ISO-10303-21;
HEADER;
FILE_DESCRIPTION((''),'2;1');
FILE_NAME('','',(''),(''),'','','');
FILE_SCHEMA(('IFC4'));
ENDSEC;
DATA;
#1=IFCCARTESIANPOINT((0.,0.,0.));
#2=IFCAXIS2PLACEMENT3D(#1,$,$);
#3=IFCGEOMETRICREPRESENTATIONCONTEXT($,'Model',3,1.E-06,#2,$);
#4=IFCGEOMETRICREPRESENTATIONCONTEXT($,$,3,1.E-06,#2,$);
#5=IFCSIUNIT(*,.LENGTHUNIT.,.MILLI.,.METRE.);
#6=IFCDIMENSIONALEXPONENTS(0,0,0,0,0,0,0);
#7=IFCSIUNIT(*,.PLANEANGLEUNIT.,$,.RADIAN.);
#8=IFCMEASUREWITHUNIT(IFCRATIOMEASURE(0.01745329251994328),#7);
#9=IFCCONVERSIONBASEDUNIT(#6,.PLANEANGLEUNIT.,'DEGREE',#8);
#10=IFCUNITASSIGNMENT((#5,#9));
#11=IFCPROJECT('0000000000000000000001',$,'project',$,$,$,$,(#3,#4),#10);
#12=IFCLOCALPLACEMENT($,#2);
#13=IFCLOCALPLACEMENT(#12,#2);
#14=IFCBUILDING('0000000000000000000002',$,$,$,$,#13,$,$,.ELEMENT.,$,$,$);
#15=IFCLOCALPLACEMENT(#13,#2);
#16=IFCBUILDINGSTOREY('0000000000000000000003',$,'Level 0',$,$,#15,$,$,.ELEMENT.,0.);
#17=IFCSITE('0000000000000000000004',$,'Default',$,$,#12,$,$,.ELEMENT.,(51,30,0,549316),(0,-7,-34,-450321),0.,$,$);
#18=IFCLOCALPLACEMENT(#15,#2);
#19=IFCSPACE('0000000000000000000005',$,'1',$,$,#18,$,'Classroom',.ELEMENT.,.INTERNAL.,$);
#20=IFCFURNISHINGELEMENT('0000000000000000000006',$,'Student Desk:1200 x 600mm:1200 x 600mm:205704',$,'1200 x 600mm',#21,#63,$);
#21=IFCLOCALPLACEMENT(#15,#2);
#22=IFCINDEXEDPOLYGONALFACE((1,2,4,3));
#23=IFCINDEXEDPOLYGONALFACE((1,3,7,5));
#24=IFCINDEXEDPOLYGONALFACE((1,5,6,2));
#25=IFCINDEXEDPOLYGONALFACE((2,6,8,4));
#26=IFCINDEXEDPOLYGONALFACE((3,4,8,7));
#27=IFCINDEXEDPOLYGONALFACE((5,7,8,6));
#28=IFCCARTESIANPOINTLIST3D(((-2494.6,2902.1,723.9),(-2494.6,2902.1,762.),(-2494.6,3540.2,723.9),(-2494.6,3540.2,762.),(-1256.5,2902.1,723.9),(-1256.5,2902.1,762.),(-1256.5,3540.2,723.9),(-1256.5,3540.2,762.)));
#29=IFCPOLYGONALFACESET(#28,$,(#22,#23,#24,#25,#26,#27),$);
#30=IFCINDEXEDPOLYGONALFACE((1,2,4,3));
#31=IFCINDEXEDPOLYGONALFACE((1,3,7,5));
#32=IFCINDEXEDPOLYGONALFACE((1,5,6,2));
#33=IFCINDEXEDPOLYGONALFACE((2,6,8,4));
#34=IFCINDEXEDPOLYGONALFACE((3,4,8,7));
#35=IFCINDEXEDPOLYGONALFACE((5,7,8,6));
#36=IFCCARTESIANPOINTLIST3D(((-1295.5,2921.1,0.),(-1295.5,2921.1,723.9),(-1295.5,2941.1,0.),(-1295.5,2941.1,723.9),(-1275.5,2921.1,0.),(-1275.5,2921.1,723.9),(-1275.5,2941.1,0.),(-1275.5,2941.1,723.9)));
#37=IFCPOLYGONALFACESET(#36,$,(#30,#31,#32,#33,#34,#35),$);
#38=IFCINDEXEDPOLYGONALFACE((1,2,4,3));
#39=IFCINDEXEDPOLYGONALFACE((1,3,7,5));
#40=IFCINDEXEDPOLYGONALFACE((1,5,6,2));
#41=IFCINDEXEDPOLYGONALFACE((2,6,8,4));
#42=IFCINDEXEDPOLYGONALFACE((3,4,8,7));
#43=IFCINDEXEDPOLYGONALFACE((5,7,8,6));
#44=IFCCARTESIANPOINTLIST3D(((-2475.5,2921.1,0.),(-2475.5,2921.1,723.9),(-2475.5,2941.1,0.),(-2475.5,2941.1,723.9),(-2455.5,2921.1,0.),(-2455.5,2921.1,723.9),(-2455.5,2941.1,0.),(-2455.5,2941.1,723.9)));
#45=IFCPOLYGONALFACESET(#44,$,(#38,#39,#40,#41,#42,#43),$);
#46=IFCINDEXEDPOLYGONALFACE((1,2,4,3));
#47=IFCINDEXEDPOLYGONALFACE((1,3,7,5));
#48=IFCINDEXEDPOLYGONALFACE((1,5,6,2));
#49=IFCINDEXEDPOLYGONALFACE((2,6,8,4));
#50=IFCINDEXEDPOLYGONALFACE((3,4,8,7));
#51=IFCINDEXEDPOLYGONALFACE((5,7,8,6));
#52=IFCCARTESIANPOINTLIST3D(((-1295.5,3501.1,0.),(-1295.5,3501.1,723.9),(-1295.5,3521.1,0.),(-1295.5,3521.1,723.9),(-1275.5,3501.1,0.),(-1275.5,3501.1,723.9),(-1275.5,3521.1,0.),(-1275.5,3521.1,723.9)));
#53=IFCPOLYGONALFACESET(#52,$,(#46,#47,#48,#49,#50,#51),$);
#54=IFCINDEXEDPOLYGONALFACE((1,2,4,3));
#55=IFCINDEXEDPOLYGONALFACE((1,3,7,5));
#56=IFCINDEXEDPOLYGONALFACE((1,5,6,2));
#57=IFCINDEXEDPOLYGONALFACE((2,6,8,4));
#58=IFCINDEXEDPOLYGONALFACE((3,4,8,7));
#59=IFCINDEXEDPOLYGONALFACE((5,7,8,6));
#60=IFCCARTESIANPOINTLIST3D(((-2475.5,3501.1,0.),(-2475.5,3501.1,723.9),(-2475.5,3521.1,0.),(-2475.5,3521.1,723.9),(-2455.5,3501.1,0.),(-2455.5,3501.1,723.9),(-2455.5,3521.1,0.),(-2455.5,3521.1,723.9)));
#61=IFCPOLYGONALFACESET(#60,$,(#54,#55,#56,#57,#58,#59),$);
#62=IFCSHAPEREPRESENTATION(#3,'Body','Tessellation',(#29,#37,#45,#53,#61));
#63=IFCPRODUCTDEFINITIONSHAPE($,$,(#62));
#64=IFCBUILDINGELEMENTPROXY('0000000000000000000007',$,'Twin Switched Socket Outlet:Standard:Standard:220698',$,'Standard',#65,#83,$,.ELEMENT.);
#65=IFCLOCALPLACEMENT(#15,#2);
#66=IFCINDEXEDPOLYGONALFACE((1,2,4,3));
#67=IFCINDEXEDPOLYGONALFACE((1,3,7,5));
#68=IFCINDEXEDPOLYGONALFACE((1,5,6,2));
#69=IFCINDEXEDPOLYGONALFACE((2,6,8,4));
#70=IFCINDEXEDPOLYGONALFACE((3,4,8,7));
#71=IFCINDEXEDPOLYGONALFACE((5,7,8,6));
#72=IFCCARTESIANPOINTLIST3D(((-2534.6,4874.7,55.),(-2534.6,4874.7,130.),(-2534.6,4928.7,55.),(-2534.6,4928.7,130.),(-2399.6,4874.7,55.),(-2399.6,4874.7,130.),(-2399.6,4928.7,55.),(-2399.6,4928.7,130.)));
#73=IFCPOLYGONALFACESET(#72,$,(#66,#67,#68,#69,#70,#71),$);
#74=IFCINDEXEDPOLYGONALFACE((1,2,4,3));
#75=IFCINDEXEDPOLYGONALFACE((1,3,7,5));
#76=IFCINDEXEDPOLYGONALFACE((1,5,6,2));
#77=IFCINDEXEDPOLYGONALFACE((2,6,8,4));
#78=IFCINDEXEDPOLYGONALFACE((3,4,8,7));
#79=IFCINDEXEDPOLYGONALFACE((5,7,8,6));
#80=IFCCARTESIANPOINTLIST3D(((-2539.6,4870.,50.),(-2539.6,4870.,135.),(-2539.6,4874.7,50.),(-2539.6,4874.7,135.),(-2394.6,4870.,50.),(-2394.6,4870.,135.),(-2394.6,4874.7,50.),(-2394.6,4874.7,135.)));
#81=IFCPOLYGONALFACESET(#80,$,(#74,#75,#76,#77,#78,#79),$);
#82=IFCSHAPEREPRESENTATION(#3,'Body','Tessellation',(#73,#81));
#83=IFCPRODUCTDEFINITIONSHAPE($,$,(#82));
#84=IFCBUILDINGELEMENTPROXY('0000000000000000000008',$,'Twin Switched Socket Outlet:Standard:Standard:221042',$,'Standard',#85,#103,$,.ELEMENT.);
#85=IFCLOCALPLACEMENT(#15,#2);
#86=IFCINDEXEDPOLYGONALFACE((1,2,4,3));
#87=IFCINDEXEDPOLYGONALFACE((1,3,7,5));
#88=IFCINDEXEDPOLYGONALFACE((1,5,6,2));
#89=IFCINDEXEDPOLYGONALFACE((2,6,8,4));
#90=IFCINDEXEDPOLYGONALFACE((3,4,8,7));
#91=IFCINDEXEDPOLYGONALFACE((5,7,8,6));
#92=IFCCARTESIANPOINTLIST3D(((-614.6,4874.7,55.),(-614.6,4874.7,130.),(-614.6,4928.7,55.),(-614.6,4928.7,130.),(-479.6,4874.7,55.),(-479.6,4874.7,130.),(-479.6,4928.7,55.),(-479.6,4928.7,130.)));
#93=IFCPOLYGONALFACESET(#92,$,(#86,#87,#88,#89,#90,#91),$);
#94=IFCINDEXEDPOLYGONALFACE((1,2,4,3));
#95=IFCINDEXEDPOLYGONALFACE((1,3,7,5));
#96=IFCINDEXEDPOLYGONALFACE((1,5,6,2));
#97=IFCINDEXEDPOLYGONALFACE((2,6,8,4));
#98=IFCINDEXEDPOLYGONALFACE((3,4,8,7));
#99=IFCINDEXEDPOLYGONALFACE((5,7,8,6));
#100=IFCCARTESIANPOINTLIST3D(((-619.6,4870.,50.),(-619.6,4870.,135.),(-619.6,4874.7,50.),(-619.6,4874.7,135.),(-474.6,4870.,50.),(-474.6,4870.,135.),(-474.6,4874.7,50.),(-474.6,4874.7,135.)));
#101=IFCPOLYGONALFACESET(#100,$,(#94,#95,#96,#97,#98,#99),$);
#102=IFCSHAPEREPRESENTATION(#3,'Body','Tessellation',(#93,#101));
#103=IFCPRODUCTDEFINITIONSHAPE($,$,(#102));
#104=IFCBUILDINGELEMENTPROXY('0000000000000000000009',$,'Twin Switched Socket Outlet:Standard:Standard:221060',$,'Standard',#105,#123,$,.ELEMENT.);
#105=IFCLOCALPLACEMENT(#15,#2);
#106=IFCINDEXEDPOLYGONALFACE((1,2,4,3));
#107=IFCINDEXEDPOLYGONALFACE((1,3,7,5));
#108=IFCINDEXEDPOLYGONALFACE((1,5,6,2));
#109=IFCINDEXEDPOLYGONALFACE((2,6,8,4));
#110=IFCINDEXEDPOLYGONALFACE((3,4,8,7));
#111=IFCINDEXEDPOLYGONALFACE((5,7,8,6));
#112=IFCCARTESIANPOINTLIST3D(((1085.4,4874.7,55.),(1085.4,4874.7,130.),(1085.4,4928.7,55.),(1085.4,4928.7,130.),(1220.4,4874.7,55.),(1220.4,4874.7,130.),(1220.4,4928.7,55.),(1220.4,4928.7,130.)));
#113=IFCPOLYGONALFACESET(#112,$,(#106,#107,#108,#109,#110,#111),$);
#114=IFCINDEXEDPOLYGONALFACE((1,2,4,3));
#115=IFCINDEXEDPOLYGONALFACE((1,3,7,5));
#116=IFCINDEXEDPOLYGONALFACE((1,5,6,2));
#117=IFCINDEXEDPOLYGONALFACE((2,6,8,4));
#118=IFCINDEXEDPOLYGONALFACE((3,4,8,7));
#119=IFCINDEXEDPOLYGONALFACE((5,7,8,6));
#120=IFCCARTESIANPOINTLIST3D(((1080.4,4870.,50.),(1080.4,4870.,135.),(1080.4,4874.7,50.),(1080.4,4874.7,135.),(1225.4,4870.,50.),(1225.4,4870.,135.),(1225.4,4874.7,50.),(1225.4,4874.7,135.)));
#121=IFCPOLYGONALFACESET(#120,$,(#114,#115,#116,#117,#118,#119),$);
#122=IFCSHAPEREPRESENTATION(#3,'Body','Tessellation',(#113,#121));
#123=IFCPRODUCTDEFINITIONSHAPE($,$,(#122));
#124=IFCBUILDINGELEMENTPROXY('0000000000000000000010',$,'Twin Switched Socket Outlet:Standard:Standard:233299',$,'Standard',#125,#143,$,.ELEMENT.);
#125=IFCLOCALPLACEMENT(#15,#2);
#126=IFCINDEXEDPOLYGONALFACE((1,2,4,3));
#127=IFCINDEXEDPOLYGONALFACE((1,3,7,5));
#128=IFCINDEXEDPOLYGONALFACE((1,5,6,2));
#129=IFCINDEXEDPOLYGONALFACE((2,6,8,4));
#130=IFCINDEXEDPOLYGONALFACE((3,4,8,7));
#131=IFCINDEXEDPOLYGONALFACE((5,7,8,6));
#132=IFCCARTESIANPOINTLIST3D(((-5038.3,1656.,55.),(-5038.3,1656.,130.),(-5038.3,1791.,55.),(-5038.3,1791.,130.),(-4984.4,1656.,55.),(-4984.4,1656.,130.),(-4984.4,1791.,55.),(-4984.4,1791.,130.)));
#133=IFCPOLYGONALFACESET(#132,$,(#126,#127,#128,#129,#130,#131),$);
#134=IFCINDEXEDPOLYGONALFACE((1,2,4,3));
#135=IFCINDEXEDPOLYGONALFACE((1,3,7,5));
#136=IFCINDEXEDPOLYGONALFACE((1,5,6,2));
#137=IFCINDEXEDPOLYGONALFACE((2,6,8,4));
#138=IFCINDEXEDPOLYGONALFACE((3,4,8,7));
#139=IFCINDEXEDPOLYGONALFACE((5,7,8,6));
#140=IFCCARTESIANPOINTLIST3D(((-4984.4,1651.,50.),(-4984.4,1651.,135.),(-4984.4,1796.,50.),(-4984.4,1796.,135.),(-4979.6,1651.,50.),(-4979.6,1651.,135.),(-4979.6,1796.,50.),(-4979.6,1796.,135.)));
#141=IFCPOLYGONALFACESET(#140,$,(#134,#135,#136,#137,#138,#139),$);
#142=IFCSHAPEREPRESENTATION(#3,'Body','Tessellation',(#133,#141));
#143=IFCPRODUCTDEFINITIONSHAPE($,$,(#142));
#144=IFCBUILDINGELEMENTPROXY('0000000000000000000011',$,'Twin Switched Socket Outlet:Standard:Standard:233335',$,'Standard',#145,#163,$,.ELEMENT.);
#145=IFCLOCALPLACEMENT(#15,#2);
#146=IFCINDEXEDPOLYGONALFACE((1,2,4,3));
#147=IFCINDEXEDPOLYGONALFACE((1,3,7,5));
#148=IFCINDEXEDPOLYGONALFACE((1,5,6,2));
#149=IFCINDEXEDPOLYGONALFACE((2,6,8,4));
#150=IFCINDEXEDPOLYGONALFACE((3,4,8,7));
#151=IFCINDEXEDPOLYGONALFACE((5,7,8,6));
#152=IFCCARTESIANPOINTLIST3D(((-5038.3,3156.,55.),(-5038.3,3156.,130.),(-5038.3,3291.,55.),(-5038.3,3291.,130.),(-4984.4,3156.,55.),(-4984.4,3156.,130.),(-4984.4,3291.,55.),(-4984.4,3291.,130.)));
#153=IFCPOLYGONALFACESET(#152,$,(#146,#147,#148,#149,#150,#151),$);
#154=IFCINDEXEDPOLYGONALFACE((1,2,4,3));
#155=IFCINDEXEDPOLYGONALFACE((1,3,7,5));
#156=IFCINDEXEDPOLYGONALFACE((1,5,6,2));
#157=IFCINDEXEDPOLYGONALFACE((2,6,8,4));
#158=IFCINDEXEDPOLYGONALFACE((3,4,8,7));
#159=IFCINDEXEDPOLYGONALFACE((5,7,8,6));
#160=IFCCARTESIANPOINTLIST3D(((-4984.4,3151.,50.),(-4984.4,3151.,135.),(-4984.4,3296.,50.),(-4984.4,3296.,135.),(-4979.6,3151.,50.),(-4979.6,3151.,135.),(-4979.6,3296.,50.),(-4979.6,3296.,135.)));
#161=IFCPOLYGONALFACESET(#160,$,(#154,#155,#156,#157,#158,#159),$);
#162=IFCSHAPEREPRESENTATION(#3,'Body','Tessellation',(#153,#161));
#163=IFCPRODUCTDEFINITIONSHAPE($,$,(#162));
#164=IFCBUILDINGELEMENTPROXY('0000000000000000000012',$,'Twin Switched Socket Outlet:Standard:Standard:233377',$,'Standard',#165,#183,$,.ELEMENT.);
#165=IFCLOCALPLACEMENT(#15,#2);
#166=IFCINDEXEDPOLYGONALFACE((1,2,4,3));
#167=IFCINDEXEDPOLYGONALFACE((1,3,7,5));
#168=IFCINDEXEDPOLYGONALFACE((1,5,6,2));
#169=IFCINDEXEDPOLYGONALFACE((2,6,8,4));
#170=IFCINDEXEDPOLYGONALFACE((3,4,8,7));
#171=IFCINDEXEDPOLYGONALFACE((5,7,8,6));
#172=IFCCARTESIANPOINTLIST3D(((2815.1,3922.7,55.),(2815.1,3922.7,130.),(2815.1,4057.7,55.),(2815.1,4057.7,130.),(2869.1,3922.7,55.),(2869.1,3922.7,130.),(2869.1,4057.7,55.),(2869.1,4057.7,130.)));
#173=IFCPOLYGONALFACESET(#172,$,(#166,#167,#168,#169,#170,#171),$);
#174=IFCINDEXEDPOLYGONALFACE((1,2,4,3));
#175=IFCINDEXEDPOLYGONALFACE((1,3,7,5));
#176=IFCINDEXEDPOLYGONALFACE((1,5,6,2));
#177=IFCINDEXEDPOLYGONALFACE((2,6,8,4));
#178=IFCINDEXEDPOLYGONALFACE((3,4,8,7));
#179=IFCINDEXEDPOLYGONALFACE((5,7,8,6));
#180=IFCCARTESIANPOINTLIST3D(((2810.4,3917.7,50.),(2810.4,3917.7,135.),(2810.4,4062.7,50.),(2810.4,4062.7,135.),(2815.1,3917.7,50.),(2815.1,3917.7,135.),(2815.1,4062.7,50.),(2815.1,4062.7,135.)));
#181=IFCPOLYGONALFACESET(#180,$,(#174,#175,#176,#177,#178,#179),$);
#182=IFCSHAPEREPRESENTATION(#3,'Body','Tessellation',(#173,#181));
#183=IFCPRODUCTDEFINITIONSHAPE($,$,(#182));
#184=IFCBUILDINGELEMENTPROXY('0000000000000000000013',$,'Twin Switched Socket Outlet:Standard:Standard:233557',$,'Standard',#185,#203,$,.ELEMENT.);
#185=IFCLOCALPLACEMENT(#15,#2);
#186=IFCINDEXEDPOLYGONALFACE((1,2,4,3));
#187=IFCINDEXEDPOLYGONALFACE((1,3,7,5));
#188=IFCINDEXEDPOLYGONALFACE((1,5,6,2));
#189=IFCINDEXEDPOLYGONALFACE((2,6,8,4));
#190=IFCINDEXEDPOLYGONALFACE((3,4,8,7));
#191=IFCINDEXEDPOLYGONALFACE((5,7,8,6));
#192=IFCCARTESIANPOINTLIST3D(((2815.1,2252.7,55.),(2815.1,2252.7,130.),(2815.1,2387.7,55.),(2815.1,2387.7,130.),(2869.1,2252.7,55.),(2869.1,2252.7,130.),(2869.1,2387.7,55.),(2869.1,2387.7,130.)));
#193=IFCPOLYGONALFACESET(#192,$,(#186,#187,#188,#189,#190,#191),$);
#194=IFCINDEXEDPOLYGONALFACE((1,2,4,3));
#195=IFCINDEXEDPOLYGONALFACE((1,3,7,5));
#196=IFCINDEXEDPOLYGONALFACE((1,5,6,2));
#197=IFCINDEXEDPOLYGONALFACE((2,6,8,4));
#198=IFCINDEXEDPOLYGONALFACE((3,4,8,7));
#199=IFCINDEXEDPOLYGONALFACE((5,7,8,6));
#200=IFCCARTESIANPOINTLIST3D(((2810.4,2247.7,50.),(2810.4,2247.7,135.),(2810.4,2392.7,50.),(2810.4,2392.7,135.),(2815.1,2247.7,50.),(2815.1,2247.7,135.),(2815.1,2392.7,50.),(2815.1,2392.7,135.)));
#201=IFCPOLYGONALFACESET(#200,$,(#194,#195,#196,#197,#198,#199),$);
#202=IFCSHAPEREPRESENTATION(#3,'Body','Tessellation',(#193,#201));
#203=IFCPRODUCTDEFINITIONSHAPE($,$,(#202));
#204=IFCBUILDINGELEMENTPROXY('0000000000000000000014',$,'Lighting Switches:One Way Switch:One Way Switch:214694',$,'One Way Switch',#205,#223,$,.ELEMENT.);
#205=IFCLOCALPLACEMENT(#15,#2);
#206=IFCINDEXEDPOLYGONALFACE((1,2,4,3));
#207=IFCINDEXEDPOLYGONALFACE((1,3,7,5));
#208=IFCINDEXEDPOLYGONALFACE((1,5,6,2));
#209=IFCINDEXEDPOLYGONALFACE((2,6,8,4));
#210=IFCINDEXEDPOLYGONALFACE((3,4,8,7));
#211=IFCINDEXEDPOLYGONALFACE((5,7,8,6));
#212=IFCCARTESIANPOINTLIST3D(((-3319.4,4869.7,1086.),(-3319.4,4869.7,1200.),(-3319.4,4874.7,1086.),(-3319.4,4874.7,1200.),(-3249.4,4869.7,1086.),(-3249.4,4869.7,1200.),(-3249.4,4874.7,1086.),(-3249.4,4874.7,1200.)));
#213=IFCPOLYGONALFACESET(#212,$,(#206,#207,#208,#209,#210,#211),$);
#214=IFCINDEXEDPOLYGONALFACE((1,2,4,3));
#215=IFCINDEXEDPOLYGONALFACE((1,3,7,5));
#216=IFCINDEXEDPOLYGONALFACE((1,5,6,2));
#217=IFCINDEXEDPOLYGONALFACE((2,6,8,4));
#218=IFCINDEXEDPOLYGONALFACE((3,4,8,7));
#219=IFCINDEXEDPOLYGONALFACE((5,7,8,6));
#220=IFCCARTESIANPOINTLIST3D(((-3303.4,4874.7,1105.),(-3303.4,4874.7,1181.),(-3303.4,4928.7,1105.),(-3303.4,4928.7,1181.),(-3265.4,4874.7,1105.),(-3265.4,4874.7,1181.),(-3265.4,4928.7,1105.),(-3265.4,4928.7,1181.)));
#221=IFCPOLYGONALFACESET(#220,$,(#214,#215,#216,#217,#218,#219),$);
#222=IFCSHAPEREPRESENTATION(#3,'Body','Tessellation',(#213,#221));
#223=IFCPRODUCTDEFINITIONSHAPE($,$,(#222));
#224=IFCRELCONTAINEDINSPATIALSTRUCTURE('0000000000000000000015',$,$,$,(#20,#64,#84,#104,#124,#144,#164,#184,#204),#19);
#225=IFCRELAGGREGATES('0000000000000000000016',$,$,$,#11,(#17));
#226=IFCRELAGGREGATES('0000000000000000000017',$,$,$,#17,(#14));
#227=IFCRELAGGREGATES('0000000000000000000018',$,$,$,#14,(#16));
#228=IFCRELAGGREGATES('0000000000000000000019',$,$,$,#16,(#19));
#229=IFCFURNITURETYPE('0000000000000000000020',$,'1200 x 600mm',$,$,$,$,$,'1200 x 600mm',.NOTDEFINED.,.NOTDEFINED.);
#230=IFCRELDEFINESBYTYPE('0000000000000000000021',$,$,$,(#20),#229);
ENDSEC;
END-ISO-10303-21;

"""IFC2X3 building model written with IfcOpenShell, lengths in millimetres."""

from ifc_helpers import new_model, entity, si_unit, converted_unit, frame, origin, origin_2d_with_axis, place, context, project, spatial, rectangle, extrude, source, transform, mapped, type_object, type_shapes, element, save


model = new_model("IFC2X3")

# Units and contexts
model_context = context("Model", 3, precision=1e-06, world=origin())
context_of_model = context(None, 3, precision=1e-06, world=origin())
ifc_project = project(units=[si_unit("LENGTHUNIT", "METRE", prefix="MILLI"), converted_unit("PLANEANGLEUNIT", "DEGREE", entity("IfcRatioMeasure", 0.01745329251994328), si_unit("PLANEANGLEUNIT", "RADIAN"), dimensions=[0, 0, 0, 0, 0, 0, 0])], contexts=[model_context, context_of_model])

# Site, building, storey
site_placement = place(None, origin())
site = spatial("IfcSite", under=ifc_project, at=site_placement, Name="Default", CompositionType="ELEMENT", RefLatitude=(51, 30, 0, 549316), RefLongitude=(0, -7, -34, -450321), RefElevation=0.0)
building_placement = place(site_placement, origin())
building = spatial("IfcBuilding", under=site, at=building_placement, CompositionType="ELEMENT")
storey_placement = place(building_placement, origin())
storey = spatial("IfcBuildingStorey", under=building, at=storey_placement, Name="Level 0", CompositionType="ELEMENT", Elevation=0.0)

# Shared definitions
space_placement = place(storey_placement, origin())
space = spatial("IfcSpace", under=storey, at=space_placement, Name="1", LongName="Classroom", CompositionType="ELEMENT", InteriorOrExteriorSpace="INTERNAL")

# Furnishing element
furniture_type = type_object("IfcFurnitureType", Name="1200 x 600mm", ElementType="1200 x 600mm", AssemblyPlace="NOTDEFINED")
shared_shape_1 = source(origin(), model_context, "Body", "SweptSolid", [
    extrude(rectangle(XDim=1238.1, YDim=638.1, at=origin_2d_with_axis()), frame((600.0, 300.0, 723.9), z_axis=(0.0, 0.0, 1.0), x_axis=(-1.0, 0.0, 0.0)), (0.0, 0.0, 1.0), 38.1),
    extrude(rectangle(XDim=20.0, YDim=20.0, at=origin_2d_with_axis()), frame((1190.0, 10.0, 0.0)), (0.0, 0.0, 1.0), 723.9),
    extrude(rectangle(XDim=20.0, YDim=20.0, at=origin_2d_with_axis()), frame((10.0, 10.0, 0.0), z_axis=(0.0, 0.0, 1.0), x_axis=(0.0, 1.0, 0.0)), (0.0, 0.0, 1.0), 723.9),
    extrude(rectangle(XDim=20.0, YDim=20.0, at=origin_2d_with_axis()), frame((1190.0, 590.0, 0.0), z_axis=(0.0, 0.0, 1.0), x_axis=(0.0, -1.0, 0.0)), (0.0, 0.0, 1.0), 723.9),
    extrude(rectangle(XDim=20.0, YDim=20.0, at=origin_2d_with_axis()), frame((10.0, 590.0, 0.0), z_axis=(0.0, 0.0, 1.0), x_axis=(-1.0, 0.0, 0.0)), (0.0, 0.0, 1.0), 723.9),
])
type_shapes(furniture_type, [shared_shape_1])
for number, where, name in (
    (1, (-2475.5, 2921.1, 0.0), "Student Desk:1200 x 600mm:1200 x 600mm:205704"),
):
    element("IfcFurnishingElement", number, at=place(space_placement, frame(where)), inside=space, type_object=furniture_type, Name=name, ObjectType="1200 x 600mm", context=model_context, shape_type="MappedRepresentation", body=[
        mapped(shared_shape_1, transform((0.0, 0.0, 0.0), scale=1.0)),
    ])

# Building element proxies
shared_shape_2 = source(origin(), model_context, "Body", "SweptSolid", [
    extrude(rectangle(XDim=135.0, YDim=75.0, at=origin_2d_with_axis()), frame((0.0, 0.0, -54.0), z_axis=(0.0, 0.0, 1.0), x_axis=(-1.0, 0.0, 0.0)), (0.0, 0.0, 1.0), 54.0),
    extrude(rectangle(XDim=145.0, YDim=85.0, at=origin_2d_with_axis()), frame((0.0, 0.0, 0.0), z_axis=(0.0, 0.0, 1.0), x_axis=(-1.0, 0.0, 0.0)), (0.0, 0.0, 1.0), 4.8),
])
for number, where, z_axis, x_axis, name in (
    (2, (-2467.1, 4874.7, 92.5), (0.0, -1.0, 0.0), (1.0, 0.0, 0.0), "Twin Switched Socket Outlet:Standard:Standard:220698"),
    (3, (-547.1, 4874.7, 92.5), (0.0, -1.0, 0.0), (1.0, 0.0, 0.0), "Twin Switched Socket Outlet:Standard:Standard:221042"),
    (4, (1152.9, 4874.7, 92.5), (0.0, -1.0, 0.0), (1.0, 0.0, 0.0), "Twin Switched Socket Outlet:Standard:Standard:221060"),
    (5, (-4984.4, 1723.5, 92.5), (1.0, 0.0, 0.0), (0.0, 1.0, 0.0), "Twin Switched Socket Outlet:Standard:Standard:233299"),
    (6, (-4984.4, 3223.5, 92.5), (1.0, 0.0, 0.0), (0.0, 1.0, 0.0), "Twin Switched Socket Outlet:Standard:Standard:233335"),
    (7, (2815.1, 3990.2, 92.5), (-1.0, 0.0, 0.0), (0.0, -1.0, 0.0), "Twin Switched Socket Outlet:Standard:Standard:233377"),
    (8, (2815.1, 2320.2, 92.5), (-1.0, 0.0, 0.0), (0.0, -1.0, 0.0), "Twin Switched Socket Outlet:Standard:Standard:233557"),
):
    element("IfcBuildingElementProxy", number, at=place(space_placement, frame(where, z_axis=z_axis, x_axis=x_axis)), inside=space, Name=name, ObjectType="Standard", CompositionType="ELEMENT", context=model_context, shape_type="MappedRepresentation", body=[
        mapped(shared_shape_2, transform((0.0, 0.0, 0.0), scale=1.0)),
    ])
shared_shape_3 = source(origin(), model_context, "Body", "SweptSolid", [
    extrude(rectangle(XDim=114.0, YDim=70.0, at=origin_2d_with_axis()), frame((0.0, -57.0, 0.0), z_axis=(0.0, 0.0, 1.0), x_axis=(0.0, 1.0, 0.0)), (0.0, 0.0, 1.0), 5.0),
    extrude(rectangle(XDim=76.0, YDim=38.0, at=origin_2d_with_axis()), frame((0.0, -57.0, -54.0), z_axis=(0.0, 0.0, 1.0), x_axis=(0.0, 1.0, 0.0)), (0.0, 0.0, 1.0), 54.0),
])
proxy_placement = place(space_placement, frame((-3284.4, 4874.7, 1200.0), z_axis=(0.0, -1.0, 0.0), x_axis=(1.0, 0.0, 0.0)))
element("IfcBuildingElementProxy", 9, at=proxy_placement, inside=space, Name="Lighting Switches:One Way Switch:One Way Switch:214694", ObjectType="One Way Switch", CompositionType="ELEMENT", context=model_context, shape_type="MappedRepresentation", body=[
    mapped(shared_shape_3, transform((0.0, 0.0, 0.0), scale=1.0)),
])

save(model, "model.ifc")
